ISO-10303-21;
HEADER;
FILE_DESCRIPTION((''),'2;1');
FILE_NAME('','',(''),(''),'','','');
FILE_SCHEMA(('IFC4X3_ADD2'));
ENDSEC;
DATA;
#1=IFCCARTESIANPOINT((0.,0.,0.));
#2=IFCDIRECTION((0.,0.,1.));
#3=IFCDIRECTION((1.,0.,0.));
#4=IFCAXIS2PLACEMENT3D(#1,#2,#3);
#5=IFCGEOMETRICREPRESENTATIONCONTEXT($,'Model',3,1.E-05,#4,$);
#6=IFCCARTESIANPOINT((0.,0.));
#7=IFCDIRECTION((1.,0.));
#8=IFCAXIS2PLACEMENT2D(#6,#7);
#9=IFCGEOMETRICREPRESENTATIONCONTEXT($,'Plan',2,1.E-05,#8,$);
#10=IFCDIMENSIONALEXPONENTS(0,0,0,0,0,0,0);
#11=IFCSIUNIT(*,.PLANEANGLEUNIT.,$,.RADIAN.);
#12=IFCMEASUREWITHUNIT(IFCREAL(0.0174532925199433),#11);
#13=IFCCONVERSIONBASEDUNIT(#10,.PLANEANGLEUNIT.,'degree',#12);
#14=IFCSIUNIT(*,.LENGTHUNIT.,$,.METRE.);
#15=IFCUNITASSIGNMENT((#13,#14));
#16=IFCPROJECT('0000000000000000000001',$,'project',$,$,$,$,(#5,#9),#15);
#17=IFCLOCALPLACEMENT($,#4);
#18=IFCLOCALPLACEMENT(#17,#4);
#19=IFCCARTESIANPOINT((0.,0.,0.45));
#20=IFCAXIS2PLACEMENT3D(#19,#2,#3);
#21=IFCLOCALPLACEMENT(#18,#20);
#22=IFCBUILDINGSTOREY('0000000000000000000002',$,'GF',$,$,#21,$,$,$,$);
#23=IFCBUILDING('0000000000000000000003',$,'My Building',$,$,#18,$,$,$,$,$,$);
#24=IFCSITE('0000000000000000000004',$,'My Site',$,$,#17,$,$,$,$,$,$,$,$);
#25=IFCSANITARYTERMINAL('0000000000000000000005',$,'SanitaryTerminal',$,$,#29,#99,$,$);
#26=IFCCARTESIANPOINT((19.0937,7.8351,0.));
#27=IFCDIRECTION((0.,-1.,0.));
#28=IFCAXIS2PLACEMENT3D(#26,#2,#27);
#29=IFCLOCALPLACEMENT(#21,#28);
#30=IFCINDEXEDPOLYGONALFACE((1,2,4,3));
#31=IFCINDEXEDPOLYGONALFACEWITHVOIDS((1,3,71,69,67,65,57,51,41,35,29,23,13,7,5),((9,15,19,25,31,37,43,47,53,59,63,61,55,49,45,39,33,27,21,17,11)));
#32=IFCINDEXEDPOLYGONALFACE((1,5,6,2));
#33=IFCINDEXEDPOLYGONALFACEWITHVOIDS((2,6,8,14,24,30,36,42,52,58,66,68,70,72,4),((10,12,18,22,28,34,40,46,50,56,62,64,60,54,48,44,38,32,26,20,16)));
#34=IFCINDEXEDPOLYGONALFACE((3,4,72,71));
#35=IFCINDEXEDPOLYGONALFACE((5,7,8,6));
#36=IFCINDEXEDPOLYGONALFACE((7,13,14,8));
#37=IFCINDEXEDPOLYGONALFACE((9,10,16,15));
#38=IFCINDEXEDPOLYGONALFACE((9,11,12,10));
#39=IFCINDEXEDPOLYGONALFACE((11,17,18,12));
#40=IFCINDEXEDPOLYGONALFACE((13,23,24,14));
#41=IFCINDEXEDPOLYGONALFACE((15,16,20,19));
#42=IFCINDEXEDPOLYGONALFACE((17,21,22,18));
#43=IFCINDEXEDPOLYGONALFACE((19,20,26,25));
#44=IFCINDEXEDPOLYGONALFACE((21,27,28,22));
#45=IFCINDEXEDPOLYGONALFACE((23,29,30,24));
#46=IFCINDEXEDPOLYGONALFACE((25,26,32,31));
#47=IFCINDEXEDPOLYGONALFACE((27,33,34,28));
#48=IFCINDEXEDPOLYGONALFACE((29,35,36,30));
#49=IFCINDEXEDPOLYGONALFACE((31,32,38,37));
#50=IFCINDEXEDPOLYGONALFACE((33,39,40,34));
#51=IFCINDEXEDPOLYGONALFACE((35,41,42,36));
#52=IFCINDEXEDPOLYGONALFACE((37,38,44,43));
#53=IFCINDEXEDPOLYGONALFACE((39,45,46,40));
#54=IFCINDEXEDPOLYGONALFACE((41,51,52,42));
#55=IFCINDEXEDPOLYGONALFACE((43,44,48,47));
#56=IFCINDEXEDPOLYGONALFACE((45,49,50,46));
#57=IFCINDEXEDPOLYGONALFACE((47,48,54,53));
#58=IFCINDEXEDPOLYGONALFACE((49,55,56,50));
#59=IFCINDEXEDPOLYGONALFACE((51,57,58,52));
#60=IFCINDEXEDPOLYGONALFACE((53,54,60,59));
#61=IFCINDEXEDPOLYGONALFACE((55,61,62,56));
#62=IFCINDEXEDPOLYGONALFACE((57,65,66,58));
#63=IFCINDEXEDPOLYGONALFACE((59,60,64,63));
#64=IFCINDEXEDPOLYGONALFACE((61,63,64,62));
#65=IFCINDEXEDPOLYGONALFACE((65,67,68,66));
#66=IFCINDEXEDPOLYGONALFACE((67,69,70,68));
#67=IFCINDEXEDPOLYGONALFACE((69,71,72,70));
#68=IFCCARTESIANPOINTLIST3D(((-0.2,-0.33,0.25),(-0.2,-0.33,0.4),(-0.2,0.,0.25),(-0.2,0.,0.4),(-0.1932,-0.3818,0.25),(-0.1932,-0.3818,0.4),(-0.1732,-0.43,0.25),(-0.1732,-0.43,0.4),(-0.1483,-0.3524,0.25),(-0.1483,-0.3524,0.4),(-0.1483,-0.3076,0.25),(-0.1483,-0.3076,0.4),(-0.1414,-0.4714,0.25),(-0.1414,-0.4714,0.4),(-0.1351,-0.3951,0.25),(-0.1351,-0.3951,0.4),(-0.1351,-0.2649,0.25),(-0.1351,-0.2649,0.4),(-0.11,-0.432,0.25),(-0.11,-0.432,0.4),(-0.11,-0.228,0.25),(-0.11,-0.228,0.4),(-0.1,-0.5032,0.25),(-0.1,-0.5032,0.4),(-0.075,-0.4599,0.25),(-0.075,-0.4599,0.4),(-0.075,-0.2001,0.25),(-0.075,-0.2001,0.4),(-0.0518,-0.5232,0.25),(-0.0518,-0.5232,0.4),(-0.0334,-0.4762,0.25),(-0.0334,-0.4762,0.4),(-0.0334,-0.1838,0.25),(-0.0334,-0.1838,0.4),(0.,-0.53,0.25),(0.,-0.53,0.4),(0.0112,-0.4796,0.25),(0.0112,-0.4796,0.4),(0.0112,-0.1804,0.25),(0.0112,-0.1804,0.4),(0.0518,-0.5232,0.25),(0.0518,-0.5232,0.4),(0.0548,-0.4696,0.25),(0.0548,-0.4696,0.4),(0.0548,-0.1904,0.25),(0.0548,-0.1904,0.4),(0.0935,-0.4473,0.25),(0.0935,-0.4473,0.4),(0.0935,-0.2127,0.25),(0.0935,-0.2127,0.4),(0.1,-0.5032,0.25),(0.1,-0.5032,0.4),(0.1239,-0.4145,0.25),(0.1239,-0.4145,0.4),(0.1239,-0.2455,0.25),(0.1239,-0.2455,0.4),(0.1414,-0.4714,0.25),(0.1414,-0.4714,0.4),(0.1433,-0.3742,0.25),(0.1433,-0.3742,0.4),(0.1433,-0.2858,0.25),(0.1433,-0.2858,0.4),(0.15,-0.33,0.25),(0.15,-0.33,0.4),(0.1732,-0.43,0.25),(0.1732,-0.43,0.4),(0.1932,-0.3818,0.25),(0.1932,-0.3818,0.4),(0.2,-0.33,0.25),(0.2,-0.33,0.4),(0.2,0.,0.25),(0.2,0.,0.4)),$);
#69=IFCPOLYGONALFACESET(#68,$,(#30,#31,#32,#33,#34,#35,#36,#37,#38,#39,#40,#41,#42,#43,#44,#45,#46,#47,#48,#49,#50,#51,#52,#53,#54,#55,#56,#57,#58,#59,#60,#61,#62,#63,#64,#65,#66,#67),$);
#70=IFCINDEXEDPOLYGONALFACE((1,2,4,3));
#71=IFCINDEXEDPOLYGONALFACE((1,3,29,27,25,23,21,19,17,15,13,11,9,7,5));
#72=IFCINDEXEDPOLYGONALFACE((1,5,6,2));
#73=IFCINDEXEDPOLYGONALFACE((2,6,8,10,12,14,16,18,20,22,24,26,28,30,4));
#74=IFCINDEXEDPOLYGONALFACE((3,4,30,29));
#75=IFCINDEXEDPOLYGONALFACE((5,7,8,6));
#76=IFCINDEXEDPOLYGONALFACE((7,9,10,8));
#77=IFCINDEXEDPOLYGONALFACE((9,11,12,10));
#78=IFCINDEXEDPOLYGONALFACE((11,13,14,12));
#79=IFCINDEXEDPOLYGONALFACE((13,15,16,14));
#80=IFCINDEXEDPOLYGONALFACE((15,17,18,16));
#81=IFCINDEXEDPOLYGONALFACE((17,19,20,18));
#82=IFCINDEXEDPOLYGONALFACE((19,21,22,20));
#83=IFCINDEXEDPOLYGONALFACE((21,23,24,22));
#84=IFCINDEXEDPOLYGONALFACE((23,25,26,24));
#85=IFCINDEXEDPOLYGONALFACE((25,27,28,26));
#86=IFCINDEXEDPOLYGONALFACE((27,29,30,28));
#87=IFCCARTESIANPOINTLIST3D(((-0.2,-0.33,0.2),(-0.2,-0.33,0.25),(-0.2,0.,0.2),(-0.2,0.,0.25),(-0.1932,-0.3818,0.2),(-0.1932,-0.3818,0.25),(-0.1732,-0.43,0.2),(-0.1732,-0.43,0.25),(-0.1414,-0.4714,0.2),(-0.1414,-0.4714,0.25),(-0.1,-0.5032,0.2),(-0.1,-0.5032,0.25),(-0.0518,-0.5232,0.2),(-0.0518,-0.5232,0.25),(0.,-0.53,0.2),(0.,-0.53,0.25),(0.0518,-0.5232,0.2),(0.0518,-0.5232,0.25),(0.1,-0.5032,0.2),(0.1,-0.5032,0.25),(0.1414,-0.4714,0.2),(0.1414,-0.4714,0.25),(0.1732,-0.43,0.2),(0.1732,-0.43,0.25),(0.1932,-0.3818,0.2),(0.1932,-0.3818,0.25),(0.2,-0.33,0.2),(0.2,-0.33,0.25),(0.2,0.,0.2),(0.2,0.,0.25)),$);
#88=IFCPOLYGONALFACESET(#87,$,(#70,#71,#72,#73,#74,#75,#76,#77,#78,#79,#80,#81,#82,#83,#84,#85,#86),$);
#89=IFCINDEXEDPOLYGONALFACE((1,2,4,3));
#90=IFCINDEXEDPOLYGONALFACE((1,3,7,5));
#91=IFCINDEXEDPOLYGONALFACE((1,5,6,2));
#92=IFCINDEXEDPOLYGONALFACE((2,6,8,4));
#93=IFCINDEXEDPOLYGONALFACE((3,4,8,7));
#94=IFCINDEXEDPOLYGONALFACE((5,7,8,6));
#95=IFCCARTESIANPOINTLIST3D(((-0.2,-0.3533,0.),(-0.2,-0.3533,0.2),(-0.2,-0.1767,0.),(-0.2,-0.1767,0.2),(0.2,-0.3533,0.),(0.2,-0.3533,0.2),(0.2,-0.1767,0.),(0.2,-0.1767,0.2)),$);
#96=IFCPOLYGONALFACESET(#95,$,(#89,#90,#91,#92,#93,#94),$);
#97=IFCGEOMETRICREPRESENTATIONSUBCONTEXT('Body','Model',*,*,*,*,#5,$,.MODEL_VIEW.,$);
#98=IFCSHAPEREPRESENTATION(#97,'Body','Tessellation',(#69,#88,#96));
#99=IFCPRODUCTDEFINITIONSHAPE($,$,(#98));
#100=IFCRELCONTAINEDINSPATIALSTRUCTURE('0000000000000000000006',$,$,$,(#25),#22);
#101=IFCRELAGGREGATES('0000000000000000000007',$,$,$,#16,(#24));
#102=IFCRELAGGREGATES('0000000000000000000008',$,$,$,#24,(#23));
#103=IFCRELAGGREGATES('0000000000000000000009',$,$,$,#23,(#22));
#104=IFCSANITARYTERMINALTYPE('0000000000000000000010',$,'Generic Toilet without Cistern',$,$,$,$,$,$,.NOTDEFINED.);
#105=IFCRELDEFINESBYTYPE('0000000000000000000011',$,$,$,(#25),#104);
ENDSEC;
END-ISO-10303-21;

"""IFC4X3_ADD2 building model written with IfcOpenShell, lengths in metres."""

from ifc_helpers import new_model, entity, si_unit, converted_unit, frame, frame_2d, origin_with_axes, origin_2d_with_axis, place, context, subcontext, project, spatial, line, arc, indexed_curve, circle_curve, outline, extrude, shape, source, transform, mapped, type_object, type_shapes, element, save


model = new_model("IFC4X3_ADD2")

# Units and contexts
model_context = context("Model", 3, precision=1e-05, world=origin_with_axes())
plan_context = context("Plan", 2, precision=1e-05, world=origin_2d_with_axis())
body_context_1 = subcontext(model_context, "Body", "Model", "MODEL_VIEW")
body_context_2 = subcontext(plan_context, "Body", "Plan", "PLAN_VIEW")
ifc_project = project(units=[converted_unit("PLANEANGLEUNIT", "degree", entity("IfcReal", 0.0174532925199433), si_unit("PLANEANGLEUNIT", "RADIAN"), dimensions=[0, 0, 0, 0, 0, 0, 0]), si_unit("LENGTHUNIT", "METRE")], contexts=[model_context, plan_context])

# Site, building, storey
site_placement = place(None, origin_with_axes())
site = spatial("IfcSite", under=ifc_project, at=site_placement, Name="My Site")
building_placement = place(site_placement, origin_with_axes())
building = spatial("IfcBuilding", under=site, at=building_placement, Name="My Building")
storey_placement = place(building_placement, frame((0.0, 0.0, 0.45), z_axis=(0.0, 0.0, 1.0), x_axis=(1.0, 0.0, 0.0)))
storey = spatial("IfcBuildingStorey", under=building, at=storey_placement, Name="GF")

# Sanitary terminal
sanitary_terminal_type_1 = type_object("IfcSanitaryTerminalType", Name="Generic Toilet without Cistern", PredefinedType="NOTDEFINED")
shared_shape_1 = source(origin_with_axes(), body_context_1, "Body", "SweptSolid", [
    extrude(outline(indexed_curve([(-0.2, 0.0), (0.2, 0.0), (0.2, -0.33), (0.1414, -0.4714), (0.0, -0.53), (-0.1414, -0.4714), (-0.2, -0.33)], segments=[line(1, 2), line(2, 3), arc(3, 4, 5), arc(5, 6, 7), line(7, 1)]), holes=[circle_curve(frame_2d((0.0, -0.33)), 0.15)]), frame((0.0, 0.0, 0.25), z_axis=(0.0, 0.0, 1.0), x_axis=(1.0, 0.0, 0.0)), (0.0, 0.0, 1.0), 0.15),
    extrude(outline(indexed_curve([(-0.2, 0.0), (0.2, 0.0), (0.2, -0.33), (0.1414, -0.4714), (0.0, -0.53), (-0.1414, -0.4714), (-0.2, -0.33)], segments=[line(1, 2), line(2, 3), arc(3, 4, 5), arc(5, 6, 7), line(7, 1)])), frame((0.0, 0.0, 0.2), z_axis=(0.0, 0.0, 1.0), x_axis=(1.0, 0.0, 0.0)), (0.0, 0.0, 1.0), 0.05),
    extrude(outline(indexed_curve([(-0.2, -0.1767), (0.2, -0.1767), (0.2, -0.3533), (-0.2, -0.3533)], segments=[line(1, 2, 3, 4, 1)])), origin_with_axes(), (0.0, 0.0, 1.0), 0.2),
])
shared_shape_2 = source(origin_with_axes(), body_context_2, "Body", "Annotation2D", [
    entity("IfcGeometricCurveSet", [entity("IfcIndexedPolyCurve", entity("IfcCartesianPointList2D", [[-0.1068, -0.124], [-0.0957, -0.1129], [-0.0804, -0.1088], [0.0804, -0.1088], [0.0957, -0.1129], [0.1068, -0.124], [0.1109, -0.1393], [0.1109, -0.3476], [0.1025, -0.3926], [0.0784, -0.4308], [0.0424, -0.4563], [0.0, -0.4652], [-0.0424, -0.4563], [-0.0784, -0.4308], [-0.1025, -0.3926], [-0.1109, -0.3476], [-0.1109, -0.1393]]), [entity("IfcLineIndex", [1, 2, 3, 4, 5, 6, 7, 8, 9, 10, 11, 12, 13, 14, 15, 16, 17, 1])]), entity("IfcIndexedPolyCurve", entity("IfcCartesianPointList2D", [[-0.1962, -0.2314], [-0.1848, -0.301], [-0.1764, -0.3339], [-0.1663, -0.3651], [-0.1546, -0.3944], [-0.1414, -0.4213], [-0.1269, -0.4458], [-0.1111, -0.4675], [-0.0943, -0.4862], [-0.0765, -0.5018], [-0.0581, -0.514], [-0.039, -0.5229], [-0.0196, -0.5282], [0.0, -0.53], [0.0196, -0.5282], [0.039, -0.5229], [0.0581, -0.514], [0.0765, -0.5018], [0.0943, -0.4862], [0.1111, -0.4675], [0.1269, -0.4458], [0.1414, -0.4213], [0.1546, -0.3944], [0.1663, -0.3651], [0.1764, -0.3339], [0.1848, -0.301], [0.1962, -0.2314], [0.2, -0.159], [0.1872, 0.0], [-0.1872, 0.0], [-0.2, -0.159]]), [entity("IfcLineIndex", [1, 2, 3, 4, 5, 6, 7, 8, 9, 10, 11, 12, 13, 14, 15, 16, 17, 18, 19, 20, 21, 22, 23, 24, 25, 26, 27, 28, 29, 30, 31, 1])])]),
])
type_shapes(sanitary_terminal_type_1, [shared_shape_1, shared_shape_2])
sanitary_terminal_1_placement = place(storey_placement, frame((19.0937, 7.8351, 0.0), z_axis=(0.0, 0.0, 1.0), x_axis=(0.0, -1.0, 0.0)))
element("IfcSanitaryTerminal", 1, at=sanitary_terminal_1_placement, inside=storey, type_object=sanitary_terminal_type_1, Name="SanitaryTerminal", shapes=[
    shape(body_context_1, "Body", "MappedRepresentation", [mapped(shared_shape_1, transform((0.0, 0.0, 0.0), x_axis=(1.0, 0.0, 0.0), y_axis=(0.0, 1.0, 0.0), z_axis=(0.0, 0.0, 1.0), scale=1.0))]),
    shape(body_context_2, "Body", "MappedRepresentation", [mapped(shared_shape_2, transform((0.0, 0.0, 0.0), x_axis=(1.0, 0.0, 0.0), y_axis=(0.0, 1.0, 0.0), z_axis=(0.0, 0.0, 1.0), scale=1.0))]),
])

save(model, "model.ifc")
